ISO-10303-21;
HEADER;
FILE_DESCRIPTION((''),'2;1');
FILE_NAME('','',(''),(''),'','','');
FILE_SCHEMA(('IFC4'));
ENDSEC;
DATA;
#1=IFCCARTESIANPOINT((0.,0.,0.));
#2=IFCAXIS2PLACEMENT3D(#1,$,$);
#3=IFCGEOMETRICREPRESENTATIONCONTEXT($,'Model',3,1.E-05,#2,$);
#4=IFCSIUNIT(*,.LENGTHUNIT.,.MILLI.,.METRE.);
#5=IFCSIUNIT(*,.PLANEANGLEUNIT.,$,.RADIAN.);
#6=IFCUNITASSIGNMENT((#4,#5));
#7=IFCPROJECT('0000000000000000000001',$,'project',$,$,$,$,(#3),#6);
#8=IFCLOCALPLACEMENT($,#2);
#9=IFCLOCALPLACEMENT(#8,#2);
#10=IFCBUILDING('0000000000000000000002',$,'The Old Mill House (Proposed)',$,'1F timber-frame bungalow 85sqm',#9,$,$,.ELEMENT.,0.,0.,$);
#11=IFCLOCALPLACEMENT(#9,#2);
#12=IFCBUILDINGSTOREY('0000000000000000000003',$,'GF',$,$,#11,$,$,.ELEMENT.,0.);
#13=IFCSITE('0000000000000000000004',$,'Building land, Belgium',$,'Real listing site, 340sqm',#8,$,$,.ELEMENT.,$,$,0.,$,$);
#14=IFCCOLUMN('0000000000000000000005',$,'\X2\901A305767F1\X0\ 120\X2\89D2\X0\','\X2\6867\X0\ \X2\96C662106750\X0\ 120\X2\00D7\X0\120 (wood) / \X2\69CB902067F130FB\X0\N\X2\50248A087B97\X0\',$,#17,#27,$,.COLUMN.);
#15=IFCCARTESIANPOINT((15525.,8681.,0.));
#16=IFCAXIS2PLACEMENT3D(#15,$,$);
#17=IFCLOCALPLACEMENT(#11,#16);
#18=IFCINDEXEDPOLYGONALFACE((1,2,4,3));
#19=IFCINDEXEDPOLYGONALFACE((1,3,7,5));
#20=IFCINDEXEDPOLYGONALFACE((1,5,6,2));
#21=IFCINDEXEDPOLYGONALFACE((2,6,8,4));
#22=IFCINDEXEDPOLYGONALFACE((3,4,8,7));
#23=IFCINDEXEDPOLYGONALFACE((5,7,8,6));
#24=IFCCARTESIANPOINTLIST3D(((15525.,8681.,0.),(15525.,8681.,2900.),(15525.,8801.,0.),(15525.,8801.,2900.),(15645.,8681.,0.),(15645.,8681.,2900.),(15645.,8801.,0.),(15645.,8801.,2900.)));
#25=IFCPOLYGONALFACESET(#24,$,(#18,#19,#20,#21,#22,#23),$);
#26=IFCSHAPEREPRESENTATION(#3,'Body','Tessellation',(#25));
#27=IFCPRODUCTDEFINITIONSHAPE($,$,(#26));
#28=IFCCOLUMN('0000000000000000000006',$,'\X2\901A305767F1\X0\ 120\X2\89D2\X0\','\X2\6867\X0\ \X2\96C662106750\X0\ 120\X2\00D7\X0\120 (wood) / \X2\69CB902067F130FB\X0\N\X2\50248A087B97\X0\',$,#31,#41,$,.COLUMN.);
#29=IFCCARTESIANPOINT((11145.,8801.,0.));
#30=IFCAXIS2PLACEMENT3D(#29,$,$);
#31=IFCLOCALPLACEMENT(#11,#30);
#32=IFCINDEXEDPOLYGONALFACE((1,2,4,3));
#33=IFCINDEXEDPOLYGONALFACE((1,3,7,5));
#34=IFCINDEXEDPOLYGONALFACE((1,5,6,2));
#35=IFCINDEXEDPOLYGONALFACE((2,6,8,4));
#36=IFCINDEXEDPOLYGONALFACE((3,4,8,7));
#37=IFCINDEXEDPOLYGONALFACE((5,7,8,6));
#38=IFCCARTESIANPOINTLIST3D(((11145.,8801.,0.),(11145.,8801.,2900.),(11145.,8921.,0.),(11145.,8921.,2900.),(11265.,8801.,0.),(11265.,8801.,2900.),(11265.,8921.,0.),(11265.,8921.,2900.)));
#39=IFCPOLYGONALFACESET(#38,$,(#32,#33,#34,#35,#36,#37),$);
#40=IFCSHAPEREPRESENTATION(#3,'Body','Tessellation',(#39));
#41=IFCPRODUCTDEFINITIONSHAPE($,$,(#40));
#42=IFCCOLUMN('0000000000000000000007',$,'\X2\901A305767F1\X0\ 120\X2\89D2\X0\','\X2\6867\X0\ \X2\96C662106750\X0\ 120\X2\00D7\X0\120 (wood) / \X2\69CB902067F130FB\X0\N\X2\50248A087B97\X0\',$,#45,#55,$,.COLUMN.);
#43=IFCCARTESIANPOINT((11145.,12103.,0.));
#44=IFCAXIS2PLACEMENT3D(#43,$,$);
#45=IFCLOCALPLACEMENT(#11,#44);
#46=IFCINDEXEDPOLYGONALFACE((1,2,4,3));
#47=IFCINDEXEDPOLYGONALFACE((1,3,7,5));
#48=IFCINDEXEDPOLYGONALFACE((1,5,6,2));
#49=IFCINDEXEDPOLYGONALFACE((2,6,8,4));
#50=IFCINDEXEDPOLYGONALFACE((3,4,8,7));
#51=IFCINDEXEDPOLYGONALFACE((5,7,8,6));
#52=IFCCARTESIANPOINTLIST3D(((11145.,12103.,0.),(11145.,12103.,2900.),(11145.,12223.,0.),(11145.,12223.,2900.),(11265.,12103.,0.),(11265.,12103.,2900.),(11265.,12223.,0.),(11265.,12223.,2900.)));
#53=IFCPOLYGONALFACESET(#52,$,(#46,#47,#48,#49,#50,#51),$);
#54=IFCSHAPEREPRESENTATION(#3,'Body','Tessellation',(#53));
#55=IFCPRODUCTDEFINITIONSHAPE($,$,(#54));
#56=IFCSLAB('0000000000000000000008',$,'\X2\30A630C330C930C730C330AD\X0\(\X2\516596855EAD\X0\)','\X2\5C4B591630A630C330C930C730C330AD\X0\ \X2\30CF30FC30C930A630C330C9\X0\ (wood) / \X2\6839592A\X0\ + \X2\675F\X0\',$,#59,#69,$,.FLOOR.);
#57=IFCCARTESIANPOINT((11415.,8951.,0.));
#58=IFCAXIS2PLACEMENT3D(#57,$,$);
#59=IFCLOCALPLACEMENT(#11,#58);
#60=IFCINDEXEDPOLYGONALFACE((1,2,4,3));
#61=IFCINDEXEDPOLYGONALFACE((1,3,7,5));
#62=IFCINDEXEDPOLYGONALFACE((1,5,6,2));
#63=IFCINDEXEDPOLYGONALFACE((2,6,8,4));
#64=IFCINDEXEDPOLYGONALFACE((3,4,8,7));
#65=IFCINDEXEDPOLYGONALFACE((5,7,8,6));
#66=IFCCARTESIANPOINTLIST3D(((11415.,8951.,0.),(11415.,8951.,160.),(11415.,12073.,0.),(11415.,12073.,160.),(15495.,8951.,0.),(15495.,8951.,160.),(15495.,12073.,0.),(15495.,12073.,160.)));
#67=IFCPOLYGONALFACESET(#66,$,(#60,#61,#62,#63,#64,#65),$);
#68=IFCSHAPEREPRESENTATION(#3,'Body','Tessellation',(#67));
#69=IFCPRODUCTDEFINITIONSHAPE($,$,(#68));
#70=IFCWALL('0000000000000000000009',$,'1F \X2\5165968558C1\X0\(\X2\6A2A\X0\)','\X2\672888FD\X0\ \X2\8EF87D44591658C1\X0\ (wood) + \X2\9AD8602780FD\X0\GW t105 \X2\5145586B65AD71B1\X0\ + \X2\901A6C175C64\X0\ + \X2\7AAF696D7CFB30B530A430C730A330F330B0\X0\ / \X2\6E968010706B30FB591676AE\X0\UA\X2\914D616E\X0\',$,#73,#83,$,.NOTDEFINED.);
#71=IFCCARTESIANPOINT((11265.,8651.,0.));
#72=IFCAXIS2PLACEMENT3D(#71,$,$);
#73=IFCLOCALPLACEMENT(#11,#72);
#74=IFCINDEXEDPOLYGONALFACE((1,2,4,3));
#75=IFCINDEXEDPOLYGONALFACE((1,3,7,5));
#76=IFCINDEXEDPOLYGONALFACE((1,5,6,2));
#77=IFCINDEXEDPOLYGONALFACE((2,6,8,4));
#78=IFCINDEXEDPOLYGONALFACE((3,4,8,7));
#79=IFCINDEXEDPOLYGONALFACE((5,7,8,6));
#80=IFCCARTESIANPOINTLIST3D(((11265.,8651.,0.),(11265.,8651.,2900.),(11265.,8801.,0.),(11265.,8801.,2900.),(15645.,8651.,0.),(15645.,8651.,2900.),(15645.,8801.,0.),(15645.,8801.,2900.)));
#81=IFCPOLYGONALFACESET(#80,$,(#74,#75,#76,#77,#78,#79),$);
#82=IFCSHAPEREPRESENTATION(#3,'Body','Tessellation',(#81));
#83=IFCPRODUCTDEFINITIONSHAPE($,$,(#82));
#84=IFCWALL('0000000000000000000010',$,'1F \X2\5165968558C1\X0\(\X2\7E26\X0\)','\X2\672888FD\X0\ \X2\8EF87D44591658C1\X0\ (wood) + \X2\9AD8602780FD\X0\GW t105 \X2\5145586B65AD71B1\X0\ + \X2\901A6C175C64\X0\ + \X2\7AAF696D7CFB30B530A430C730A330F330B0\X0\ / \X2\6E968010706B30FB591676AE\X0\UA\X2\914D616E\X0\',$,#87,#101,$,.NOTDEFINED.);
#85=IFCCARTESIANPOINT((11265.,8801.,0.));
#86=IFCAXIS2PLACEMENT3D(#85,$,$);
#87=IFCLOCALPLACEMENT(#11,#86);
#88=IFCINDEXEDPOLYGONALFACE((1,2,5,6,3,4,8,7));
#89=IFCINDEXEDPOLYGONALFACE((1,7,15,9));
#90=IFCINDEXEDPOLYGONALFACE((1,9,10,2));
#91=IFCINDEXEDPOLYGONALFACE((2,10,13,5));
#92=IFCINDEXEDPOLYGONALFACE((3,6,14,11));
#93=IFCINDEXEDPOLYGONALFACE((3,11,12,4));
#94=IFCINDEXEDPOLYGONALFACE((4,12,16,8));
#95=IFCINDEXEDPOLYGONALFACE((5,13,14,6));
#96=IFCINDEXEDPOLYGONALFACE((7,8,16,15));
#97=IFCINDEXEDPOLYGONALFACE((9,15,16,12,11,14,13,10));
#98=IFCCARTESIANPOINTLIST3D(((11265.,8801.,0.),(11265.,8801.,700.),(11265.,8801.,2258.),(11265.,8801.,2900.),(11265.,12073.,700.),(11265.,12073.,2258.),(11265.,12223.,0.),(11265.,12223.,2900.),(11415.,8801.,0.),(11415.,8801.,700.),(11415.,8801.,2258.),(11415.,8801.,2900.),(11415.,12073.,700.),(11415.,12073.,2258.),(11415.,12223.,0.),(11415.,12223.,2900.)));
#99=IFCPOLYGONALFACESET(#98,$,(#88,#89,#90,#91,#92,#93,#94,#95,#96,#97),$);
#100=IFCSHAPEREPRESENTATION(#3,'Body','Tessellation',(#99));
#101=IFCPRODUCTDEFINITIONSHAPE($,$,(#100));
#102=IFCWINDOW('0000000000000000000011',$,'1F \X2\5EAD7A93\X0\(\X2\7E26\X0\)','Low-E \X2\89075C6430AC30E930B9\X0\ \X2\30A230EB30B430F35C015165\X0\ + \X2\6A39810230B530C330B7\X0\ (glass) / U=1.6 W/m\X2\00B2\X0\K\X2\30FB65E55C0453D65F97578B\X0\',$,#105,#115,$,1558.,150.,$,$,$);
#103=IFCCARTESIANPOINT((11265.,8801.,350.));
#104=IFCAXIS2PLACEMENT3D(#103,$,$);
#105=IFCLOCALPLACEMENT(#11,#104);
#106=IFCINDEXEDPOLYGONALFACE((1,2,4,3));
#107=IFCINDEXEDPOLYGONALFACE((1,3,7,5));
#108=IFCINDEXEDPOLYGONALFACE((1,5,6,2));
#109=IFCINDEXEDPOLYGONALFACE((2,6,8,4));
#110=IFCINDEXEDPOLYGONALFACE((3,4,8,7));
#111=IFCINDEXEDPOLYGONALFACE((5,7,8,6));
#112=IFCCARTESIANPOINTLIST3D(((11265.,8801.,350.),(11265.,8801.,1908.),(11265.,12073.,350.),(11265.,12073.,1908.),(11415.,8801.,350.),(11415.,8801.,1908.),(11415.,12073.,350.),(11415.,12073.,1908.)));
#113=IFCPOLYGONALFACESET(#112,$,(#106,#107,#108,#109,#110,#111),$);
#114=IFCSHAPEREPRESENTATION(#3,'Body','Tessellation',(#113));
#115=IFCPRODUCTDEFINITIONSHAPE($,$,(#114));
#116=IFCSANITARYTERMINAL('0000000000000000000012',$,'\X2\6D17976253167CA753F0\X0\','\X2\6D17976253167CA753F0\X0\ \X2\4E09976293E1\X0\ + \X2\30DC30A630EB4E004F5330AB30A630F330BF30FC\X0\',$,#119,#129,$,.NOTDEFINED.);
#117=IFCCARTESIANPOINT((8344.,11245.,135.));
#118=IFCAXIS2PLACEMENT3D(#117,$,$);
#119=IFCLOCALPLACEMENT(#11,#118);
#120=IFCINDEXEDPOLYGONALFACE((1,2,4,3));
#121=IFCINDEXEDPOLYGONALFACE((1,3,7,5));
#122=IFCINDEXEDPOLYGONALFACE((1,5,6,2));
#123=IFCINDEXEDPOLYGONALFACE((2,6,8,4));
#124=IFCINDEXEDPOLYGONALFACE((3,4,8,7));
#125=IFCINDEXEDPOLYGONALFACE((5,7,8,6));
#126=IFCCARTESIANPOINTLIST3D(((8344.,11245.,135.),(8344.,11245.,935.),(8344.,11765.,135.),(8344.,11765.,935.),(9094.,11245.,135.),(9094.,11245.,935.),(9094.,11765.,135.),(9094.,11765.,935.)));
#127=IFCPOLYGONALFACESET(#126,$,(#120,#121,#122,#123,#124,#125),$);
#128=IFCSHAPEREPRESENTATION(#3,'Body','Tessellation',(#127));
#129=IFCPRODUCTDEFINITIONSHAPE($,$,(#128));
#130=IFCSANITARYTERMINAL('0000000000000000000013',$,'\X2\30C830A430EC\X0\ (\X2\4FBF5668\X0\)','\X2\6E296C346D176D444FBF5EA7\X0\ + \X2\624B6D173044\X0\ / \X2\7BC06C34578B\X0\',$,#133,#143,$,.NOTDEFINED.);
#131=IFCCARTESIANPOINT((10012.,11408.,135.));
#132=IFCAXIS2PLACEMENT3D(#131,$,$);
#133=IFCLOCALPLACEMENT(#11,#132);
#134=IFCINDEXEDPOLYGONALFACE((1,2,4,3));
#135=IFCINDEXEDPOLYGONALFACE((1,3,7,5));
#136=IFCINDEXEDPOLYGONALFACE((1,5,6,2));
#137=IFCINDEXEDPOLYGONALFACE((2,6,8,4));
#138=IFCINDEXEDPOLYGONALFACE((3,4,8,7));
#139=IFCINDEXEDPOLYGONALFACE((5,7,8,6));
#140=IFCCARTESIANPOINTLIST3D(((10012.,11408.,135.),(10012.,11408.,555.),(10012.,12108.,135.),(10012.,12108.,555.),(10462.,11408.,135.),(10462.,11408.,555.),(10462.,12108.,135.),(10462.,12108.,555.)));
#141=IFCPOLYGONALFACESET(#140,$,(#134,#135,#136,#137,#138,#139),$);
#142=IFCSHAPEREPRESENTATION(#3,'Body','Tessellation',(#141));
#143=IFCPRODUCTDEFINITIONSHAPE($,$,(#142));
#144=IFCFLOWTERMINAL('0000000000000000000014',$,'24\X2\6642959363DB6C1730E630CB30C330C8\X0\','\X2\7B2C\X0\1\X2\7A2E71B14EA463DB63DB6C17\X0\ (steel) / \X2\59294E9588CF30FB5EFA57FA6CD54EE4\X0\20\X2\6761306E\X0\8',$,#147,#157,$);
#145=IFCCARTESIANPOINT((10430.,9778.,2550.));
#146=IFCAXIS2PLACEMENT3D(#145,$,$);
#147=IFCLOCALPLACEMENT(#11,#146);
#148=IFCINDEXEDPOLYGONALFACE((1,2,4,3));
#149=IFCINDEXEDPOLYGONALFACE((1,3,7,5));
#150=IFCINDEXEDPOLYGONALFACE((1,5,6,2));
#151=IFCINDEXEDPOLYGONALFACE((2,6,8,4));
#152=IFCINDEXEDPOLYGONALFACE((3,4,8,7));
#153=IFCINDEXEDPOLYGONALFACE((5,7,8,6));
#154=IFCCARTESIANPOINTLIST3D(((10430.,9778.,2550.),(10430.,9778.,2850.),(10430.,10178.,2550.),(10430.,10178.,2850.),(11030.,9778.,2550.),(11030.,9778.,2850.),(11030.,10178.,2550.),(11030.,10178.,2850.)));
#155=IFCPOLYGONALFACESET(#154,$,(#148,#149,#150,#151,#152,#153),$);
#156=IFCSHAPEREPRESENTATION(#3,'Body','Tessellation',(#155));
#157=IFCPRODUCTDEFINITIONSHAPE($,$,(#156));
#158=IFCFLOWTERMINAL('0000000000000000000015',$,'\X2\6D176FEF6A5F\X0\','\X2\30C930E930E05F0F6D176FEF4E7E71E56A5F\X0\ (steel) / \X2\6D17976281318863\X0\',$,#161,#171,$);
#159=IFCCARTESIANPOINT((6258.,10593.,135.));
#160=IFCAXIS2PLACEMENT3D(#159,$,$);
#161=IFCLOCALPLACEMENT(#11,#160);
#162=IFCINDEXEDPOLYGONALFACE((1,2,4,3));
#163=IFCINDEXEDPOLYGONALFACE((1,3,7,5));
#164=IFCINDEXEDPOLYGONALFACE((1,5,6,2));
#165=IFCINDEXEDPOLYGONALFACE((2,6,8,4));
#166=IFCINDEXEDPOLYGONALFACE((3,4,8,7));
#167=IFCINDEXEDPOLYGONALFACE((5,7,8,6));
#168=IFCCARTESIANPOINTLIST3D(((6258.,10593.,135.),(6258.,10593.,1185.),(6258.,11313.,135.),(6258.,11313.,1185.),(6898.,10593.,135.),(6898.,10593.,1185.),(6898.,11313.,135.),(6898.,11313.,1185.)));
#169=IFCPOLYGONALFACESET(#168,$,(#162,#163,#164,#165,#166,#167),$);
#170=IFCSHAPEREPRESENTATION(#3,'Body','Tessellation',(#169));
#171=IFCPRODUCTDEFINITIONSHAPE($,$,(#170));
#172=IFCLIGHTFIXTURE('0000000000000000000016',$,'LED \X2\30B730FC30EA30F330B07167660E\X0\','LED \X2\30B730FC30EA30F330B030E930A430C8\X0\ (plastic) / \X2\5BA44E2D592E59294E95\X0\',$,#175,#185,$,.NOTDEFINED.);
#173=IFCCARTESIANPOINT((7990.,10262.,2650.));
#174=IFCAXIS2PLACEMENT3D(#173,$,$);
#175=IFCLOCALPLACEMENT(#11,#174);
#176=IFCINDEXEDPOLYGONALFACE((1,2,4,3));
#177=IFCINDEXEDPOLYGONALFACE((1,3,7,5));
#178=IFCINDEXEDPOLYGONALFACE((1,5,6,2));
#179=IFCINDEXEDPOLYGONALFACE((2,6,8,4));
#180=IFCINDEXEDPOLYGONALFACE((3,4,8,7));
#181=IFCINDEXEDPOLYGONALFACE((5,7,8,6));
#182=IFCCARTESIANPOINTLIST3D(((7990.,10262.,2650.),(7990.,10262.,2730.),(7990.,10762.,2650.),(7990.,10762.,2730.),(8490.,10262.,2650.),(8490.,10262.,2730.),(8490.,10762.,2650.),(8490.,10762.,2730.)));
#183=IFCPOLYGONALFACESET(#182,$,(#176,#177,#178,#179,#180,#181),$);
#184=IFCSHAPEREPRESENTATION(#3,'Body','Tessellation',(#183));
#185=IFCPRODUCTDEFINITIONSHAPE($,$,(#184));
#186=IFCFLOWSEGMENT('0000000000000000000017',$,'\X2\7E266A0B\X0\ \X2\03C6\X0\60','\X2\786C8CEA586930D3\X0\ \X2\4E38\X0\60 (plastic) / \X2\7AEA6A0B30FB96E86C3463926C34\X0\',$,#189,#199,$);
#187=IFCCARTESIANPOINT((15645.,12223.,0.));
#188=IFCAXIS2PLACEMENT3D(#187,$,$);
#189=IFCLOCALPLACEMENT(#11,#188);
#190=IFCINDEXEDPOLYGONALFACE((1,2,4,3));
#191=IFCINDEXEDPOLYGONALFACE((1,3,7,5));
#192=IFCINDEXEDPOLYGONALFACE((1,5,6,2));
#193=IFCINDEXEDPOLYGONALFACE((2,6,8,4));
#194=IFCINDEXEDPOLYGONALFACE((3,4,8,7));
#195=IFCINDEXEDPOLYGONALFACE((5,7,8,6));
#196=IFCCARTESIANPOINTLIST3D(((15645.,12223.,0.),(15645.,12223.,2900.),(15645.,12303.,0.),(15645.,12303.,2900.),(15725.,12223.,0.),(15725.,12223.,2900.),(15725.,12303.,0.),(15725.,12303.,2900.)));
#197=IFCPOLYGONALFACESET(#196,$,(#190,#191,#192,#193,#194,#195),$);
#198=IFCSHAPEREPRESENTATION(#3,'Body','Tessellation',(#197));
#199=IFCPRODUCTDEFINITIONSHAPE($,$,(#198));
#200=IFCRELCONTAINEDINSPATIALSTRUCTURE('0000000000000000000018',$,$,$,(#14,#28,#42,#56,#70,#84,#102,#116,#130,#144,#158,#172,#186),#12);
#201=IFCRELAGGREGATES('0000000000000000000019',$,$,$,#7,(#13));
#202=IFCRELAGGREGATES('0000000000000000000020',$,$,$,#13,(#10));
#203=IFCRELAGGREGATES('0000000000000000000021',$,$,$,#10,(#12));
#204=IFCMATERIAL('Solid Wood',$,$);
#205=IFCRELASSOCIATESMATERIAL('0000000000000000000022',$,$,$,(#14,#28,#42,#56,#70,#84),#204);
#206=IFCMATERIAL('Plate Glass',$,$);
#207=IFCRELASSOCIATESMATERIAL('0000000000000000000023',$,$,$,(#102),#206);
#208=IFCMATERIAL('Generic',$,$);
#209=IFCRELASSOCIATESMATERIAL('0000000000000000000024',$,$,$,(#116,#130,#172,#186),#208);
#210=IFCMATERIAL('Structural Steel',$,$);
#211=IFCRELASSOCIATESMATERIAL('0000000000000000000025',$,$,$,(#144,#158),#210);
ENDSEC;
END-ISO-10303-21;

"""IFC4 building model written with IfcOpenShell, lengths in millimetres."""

from ifc_helpers import new_model, si_unit, frame, frame_2d, origin, place, context, project, spatial, rectangle, extrude, material, element, fill, save


model = new_model("IFC4")

# Units and contexts
model_context = context("Model", 3, precision=1e-05, world=origin())
ifc_project = project(units=[si_unit("LENGTHUNIT", "METRE", prefix="MILLI"), si_unit("PLANEANGLEUNIT", "RADIAN")], contexts=[model_context])

# Site, building, storey
site_placement = place(None, origin())
site = spatial("IfcSite", under=ifc_project, at=site_placement, Name="Building land, Belgium", ObjectType="Real listing site, 340sqm", CompositionType="ELEMENT", RefElevation=0.0)
building_placement = place(site_placement, origin())
building = spatial("IfcBuilding", under=site, at=building_placement, Name="The Old Mill House (Proposed)", ObjectType="1F timber-frame bungalow 85sqm", CompositionType="ELEMENT", ElevationOfRefHeight=0.0, ElevationOfTerrain=0.0)
storey_placement = place(building_placement, origin())
storey = spatial("IfcBuildingStorey", under=building, at=storey_placement, Name="GF", CompositionType="ELEMENT", Elevation=0.0)

# Columns
ifc_material_1 = material(Name="Solid Wood")
column_1_placement = place(storey_placement, frame((15525.0, 8681.0, 0.0)))
element("IfcColumn", 1, at=column_1_placement, inside=storey, material=ifc_material_1, Name="通し柱 120角", Description="桧 集成材 120×120 (wood) / 構造柱・N値計算", PredefinedType="COLUMN", context=model_context, shape_type="SweptSolid", body=[
    extrude(rectangle(XDim=120.0, YDim=120.0, at=frame_2d((60.0, 60.0))), frame((15525.0, 8681.0, 0.0)), (0.0, 0.0, 1.0), 2900.0),
])
column_2_placement = place(storey_placement, frame((11145.0, 8801.0, 0.0)))
element("IfcColumn", 2, at=column_2_placement, inside=storey, material=ifc_material_1, Name="通し柱 120角", Description="桧 集成材 120×120 (wood) / 構造柱・N値計算", PredefinedType="COLUMN", context=model_context, shape_type="SweptSolid", body=[
    extrude(rectangle(XDim=120.0, YDim=120.0, at=frame_2d((60.0, 60.0))), frame((11145.0, 8801.0, 0.0)), (0.0, 0.0, 1.0), 2900.0),
])
column_3_placement = place(storey_placement, frame((11145.0, 12103.0, 0.0)))
element("IfcColumn", 3, at=column_3_placement, inside=storey, material=ifc_material_1, Name="通し柱 120角", Description="桧 集成材 120×120 (wood) / 構造柱・N値計算", PredefinedType="COLUMN", context=model_context, shape_type="SweptSolid", body=[
    extrude(rectangle(XDim=120.0, YDim=120.0, at=frame_2d((60.0, 60.0))), frame((11145.0, 12103.0, 0.0)), (0.0, 0.0, 1.0), 2900.0),
])

# Slab
slab_placement = place(storey_placement, frame((11415.0, 8951.0, 0.0)))
element("IfcSlab", 4, at=slab_placement, inside=storey, material=ifc_material_1, Name="ウッドデッキ(入隅庭)", Description="屋外ウッドデッキ ハードウッド (wood) / 根太 + 束", PredefinedType="FLOOR", context=model_context, shape_type="SweptSolid", body=[
    extrude(rectangle(XDim=4080.0, YDim=3122.0, at=frame_2d((2040.0, 1561.0))), frame((11415.0, 8951.0, 0.0)), (0.0, 0.0, 1.0), 160.0),
])

# Wall
wall_1_placement = place(storey_placement, frame((11265.0, 8651.0, 0.0)))
element("IfcWall", 5, at=wall_1_placement, inside=storey, material=ifc_material_1, Name="1F 入隅壁(横)", Description="木製 軸組外壁 (wood) + 高性能GW t105 充填断熱 + 通気層 + 窯業系サイディング / 準耐火・外皮UA配慮", PredefinedType="NOTDEFINED", context=model_context, shape_type="SweptSolid", body=[
    extrude(rectangle(XDim=4380.0, YDim=150.0, at=frame_2d((2190.0, 75.0))), frame((11265.0, 8651.0, 0.0)), (0.0, 0.0, 1.0), 2900.0),
])

# Wall, opening, window
wall_2_placement = place(storey_placement, frame((11265.0, 8801.0, 0.0)))
wall_2 = element("IfcWall", 6, at=wall_2_placement, inside=storey, material=ifc_material_1, Name="1F 入隅壁(縦)", Description="木製 軸組外壁 (wood) + 高性能GW t105 充填断熱 + 通気層 + 窯業系サイディング / 準耐火・外皮UA配慮", PredefinedType="NOTDEFINED", context=model_context, shape_type="SweptSolid", body=[
    extrude(rectangle(XDim=150.0, YDim=3422.0, at=frame_2d((75.0, 1711.0))), frame((11265.0, 8801.0, 0.0)), (0.0, 0.0, 1.0), 2900.0),
])
opening_placement = place(storey_placement, frame((11265.0, 8801.0, 350.0)))
opening = element("IfcOpeningElement", 7, at=opening_placement, cuts=wall_2, PredefinedType="NOTDEFINED", context=model_context, shape_type="SweptSolid", body=[
    extrude(rectangle(XDim=150.0, YDim=3272.0, at=frame_2d((75.0, 1636.0))), frame((11265.0, 8801.0, 350.0)), (0.0, 0.0, 1.0), 1558.0),
])
ifc_material_2 = material(Name="Plate Glass")
window_placement = place(storey_placement, frame((11265.0, 8801.0, 350.0)))
window = element("IfcWindow", 8, at=window_placement, inside=storey, material=ifc_material_2, Name="1F 庭窓(縦)", Description="Low-E 複層ガラス アルゴン封入 + 樹脂サッシ (glass) / U=1.6 W/m²K・日射取得型", OverallHeight=1558.0, OverallWidth=150.0, context=model_context, shape_type="SweptSolid", body=[
    extrude(rectangle(XDim=150.0, YDim=3272.0, at=frame_2d((75.0, 1636.0))), frame((11265.0, 8801.0, 350.0)), (0.0, 0.0, 1.0), 1558.0),
])
fill(opening, window)

# Sanitary terminals
ifc_material_3 = material(Name="Generic")
sanitary_terminal_1_placement = place(storey_placement, frame((8344.0, 11245.0, 135.0)))
element("IfcSanitaryTerminal", 9, at=sanitary_terminal_1_placement, inside=storey, material=ifc_material_3, Name="洗面化粧台", Description="洗面化粧台 三面鏡 + ボウル一体カウンター", PredefinedType="NOTDEFINED", context=model_context, shape_type="SweptSolid", body=[
    extrude(rectangle(XDim=750.0, YDim=520.0, at=frame_2d((375.0, 260.0))), frame((8344.0, 11245.0, 135.0)), (0.0, 0.0, 1.0), 800.0),
])
sanitary_terminal_2_placement = place(storey_placement, frame((10012.0, 11408.0, 135.0)))
element("IfcSanitaryTerminal", 10, at=sanitary_terminal_2_placement, inside=storey, material=ifc_material_3, Name="トイレ (便器)", Description="温水洗浄便座 + 手洗い / 節水型", PredefinedType="NOTDEFINED", context=model_context, shape_type="SweptSolid", body=[
    extrude(rectangle(XDim=450.0, YDim=700.0, at=frame_2d((225.0, 350.0))), frame((10012.0, 11408.0, 135.0)), (0.0, 0.0, 1.0), 420.0),
])

# Flow terminals
ifc_material_4 = material(Name="Structural Steel")
flow_terminal_1_placement = place(storey_placement, frame((10430.0, 9778.0, 2550.0)))
element("IfcFlowTerminal", 11, at=flow_terminal_1_placement, inside=storey, material=ifc_material_4, Name="24時間換気ユニット", Description="第1種熱交換換気 (steel) / 天井裏・建基法令20条の8", context=model_context, shape_type="SweptSolid", body=[
    extrude(rectangle(XDim=600.0, YDim=400.0, at=frame_2d((300.0, 200.0))), frame((10430.0, 9778.0, 2550.0)), (0.0, 0.0, 1.0), 300.0),
])
flow_terminal_2_placement = place(storey_placement, frame((6258.0, 10593.0, 135.0)))
element("IfcFlowTerminal", 12, at=flow_terminal_2_placement, inside=storey, material=ifc_material_4, Name="洗濯機", Description="ドラム式洗濯乾燥機 (steel) / 洗面脱衣", context=model_context, shape_type="SweptSolid", body=[
    extrude(rectangle(XDim=640.0, YDim=720.0, at=frame_2d((320.0, 360.0))), frame((6258.0, 10593.0, 135.0)), (0.0, 0.0, 1.0), 1050.0),
])

# Light fixture
light_fixture_placement = place(storey_placement, frame((7990.0, 10262.0, 2650.0)))
element("IfcLightFixture", 13, at=light_fixture_placement, inside=storey, material=ifc_material_3, Name="LED シーリング照明", Description="LED シーリングライト (plastic) / 室中央天井", PredefinedType="NOTDEFINED", context=model_context, shape_type="SweptSolid", body=[
    extrude(rectangle(XDim=500.0, YDim=500.0, at=frame_2d((250.0, 250.0))), frame((7990.0, 10262.0, 2650.0)), (0.0, 0.0, 1.0), 80.0),
])

# Flow segment
flow_segment_placement = place(storey_placement, frame((15645.0, 12223.0, 0.0)))
element("IfcFlowSegment", 14, at=flow_segment_placement, inside=storey, material=ifc_material_3, Name="縦樋 φ60", Description="硬質塩ビ 丸60 (plastic) / 竪樋・雨水排水", context=model_context, shape_type="SweptSolid", body=[
    extrude(rectangle(XDim=80.0, YDim=80.0, at=frame_2d((40.0, 40.0))), frame((15645.0, 12223.0, 0.0)), (0.0, 0.0, 1.0), 2900.0),
])

save(model, "model.ifc")
